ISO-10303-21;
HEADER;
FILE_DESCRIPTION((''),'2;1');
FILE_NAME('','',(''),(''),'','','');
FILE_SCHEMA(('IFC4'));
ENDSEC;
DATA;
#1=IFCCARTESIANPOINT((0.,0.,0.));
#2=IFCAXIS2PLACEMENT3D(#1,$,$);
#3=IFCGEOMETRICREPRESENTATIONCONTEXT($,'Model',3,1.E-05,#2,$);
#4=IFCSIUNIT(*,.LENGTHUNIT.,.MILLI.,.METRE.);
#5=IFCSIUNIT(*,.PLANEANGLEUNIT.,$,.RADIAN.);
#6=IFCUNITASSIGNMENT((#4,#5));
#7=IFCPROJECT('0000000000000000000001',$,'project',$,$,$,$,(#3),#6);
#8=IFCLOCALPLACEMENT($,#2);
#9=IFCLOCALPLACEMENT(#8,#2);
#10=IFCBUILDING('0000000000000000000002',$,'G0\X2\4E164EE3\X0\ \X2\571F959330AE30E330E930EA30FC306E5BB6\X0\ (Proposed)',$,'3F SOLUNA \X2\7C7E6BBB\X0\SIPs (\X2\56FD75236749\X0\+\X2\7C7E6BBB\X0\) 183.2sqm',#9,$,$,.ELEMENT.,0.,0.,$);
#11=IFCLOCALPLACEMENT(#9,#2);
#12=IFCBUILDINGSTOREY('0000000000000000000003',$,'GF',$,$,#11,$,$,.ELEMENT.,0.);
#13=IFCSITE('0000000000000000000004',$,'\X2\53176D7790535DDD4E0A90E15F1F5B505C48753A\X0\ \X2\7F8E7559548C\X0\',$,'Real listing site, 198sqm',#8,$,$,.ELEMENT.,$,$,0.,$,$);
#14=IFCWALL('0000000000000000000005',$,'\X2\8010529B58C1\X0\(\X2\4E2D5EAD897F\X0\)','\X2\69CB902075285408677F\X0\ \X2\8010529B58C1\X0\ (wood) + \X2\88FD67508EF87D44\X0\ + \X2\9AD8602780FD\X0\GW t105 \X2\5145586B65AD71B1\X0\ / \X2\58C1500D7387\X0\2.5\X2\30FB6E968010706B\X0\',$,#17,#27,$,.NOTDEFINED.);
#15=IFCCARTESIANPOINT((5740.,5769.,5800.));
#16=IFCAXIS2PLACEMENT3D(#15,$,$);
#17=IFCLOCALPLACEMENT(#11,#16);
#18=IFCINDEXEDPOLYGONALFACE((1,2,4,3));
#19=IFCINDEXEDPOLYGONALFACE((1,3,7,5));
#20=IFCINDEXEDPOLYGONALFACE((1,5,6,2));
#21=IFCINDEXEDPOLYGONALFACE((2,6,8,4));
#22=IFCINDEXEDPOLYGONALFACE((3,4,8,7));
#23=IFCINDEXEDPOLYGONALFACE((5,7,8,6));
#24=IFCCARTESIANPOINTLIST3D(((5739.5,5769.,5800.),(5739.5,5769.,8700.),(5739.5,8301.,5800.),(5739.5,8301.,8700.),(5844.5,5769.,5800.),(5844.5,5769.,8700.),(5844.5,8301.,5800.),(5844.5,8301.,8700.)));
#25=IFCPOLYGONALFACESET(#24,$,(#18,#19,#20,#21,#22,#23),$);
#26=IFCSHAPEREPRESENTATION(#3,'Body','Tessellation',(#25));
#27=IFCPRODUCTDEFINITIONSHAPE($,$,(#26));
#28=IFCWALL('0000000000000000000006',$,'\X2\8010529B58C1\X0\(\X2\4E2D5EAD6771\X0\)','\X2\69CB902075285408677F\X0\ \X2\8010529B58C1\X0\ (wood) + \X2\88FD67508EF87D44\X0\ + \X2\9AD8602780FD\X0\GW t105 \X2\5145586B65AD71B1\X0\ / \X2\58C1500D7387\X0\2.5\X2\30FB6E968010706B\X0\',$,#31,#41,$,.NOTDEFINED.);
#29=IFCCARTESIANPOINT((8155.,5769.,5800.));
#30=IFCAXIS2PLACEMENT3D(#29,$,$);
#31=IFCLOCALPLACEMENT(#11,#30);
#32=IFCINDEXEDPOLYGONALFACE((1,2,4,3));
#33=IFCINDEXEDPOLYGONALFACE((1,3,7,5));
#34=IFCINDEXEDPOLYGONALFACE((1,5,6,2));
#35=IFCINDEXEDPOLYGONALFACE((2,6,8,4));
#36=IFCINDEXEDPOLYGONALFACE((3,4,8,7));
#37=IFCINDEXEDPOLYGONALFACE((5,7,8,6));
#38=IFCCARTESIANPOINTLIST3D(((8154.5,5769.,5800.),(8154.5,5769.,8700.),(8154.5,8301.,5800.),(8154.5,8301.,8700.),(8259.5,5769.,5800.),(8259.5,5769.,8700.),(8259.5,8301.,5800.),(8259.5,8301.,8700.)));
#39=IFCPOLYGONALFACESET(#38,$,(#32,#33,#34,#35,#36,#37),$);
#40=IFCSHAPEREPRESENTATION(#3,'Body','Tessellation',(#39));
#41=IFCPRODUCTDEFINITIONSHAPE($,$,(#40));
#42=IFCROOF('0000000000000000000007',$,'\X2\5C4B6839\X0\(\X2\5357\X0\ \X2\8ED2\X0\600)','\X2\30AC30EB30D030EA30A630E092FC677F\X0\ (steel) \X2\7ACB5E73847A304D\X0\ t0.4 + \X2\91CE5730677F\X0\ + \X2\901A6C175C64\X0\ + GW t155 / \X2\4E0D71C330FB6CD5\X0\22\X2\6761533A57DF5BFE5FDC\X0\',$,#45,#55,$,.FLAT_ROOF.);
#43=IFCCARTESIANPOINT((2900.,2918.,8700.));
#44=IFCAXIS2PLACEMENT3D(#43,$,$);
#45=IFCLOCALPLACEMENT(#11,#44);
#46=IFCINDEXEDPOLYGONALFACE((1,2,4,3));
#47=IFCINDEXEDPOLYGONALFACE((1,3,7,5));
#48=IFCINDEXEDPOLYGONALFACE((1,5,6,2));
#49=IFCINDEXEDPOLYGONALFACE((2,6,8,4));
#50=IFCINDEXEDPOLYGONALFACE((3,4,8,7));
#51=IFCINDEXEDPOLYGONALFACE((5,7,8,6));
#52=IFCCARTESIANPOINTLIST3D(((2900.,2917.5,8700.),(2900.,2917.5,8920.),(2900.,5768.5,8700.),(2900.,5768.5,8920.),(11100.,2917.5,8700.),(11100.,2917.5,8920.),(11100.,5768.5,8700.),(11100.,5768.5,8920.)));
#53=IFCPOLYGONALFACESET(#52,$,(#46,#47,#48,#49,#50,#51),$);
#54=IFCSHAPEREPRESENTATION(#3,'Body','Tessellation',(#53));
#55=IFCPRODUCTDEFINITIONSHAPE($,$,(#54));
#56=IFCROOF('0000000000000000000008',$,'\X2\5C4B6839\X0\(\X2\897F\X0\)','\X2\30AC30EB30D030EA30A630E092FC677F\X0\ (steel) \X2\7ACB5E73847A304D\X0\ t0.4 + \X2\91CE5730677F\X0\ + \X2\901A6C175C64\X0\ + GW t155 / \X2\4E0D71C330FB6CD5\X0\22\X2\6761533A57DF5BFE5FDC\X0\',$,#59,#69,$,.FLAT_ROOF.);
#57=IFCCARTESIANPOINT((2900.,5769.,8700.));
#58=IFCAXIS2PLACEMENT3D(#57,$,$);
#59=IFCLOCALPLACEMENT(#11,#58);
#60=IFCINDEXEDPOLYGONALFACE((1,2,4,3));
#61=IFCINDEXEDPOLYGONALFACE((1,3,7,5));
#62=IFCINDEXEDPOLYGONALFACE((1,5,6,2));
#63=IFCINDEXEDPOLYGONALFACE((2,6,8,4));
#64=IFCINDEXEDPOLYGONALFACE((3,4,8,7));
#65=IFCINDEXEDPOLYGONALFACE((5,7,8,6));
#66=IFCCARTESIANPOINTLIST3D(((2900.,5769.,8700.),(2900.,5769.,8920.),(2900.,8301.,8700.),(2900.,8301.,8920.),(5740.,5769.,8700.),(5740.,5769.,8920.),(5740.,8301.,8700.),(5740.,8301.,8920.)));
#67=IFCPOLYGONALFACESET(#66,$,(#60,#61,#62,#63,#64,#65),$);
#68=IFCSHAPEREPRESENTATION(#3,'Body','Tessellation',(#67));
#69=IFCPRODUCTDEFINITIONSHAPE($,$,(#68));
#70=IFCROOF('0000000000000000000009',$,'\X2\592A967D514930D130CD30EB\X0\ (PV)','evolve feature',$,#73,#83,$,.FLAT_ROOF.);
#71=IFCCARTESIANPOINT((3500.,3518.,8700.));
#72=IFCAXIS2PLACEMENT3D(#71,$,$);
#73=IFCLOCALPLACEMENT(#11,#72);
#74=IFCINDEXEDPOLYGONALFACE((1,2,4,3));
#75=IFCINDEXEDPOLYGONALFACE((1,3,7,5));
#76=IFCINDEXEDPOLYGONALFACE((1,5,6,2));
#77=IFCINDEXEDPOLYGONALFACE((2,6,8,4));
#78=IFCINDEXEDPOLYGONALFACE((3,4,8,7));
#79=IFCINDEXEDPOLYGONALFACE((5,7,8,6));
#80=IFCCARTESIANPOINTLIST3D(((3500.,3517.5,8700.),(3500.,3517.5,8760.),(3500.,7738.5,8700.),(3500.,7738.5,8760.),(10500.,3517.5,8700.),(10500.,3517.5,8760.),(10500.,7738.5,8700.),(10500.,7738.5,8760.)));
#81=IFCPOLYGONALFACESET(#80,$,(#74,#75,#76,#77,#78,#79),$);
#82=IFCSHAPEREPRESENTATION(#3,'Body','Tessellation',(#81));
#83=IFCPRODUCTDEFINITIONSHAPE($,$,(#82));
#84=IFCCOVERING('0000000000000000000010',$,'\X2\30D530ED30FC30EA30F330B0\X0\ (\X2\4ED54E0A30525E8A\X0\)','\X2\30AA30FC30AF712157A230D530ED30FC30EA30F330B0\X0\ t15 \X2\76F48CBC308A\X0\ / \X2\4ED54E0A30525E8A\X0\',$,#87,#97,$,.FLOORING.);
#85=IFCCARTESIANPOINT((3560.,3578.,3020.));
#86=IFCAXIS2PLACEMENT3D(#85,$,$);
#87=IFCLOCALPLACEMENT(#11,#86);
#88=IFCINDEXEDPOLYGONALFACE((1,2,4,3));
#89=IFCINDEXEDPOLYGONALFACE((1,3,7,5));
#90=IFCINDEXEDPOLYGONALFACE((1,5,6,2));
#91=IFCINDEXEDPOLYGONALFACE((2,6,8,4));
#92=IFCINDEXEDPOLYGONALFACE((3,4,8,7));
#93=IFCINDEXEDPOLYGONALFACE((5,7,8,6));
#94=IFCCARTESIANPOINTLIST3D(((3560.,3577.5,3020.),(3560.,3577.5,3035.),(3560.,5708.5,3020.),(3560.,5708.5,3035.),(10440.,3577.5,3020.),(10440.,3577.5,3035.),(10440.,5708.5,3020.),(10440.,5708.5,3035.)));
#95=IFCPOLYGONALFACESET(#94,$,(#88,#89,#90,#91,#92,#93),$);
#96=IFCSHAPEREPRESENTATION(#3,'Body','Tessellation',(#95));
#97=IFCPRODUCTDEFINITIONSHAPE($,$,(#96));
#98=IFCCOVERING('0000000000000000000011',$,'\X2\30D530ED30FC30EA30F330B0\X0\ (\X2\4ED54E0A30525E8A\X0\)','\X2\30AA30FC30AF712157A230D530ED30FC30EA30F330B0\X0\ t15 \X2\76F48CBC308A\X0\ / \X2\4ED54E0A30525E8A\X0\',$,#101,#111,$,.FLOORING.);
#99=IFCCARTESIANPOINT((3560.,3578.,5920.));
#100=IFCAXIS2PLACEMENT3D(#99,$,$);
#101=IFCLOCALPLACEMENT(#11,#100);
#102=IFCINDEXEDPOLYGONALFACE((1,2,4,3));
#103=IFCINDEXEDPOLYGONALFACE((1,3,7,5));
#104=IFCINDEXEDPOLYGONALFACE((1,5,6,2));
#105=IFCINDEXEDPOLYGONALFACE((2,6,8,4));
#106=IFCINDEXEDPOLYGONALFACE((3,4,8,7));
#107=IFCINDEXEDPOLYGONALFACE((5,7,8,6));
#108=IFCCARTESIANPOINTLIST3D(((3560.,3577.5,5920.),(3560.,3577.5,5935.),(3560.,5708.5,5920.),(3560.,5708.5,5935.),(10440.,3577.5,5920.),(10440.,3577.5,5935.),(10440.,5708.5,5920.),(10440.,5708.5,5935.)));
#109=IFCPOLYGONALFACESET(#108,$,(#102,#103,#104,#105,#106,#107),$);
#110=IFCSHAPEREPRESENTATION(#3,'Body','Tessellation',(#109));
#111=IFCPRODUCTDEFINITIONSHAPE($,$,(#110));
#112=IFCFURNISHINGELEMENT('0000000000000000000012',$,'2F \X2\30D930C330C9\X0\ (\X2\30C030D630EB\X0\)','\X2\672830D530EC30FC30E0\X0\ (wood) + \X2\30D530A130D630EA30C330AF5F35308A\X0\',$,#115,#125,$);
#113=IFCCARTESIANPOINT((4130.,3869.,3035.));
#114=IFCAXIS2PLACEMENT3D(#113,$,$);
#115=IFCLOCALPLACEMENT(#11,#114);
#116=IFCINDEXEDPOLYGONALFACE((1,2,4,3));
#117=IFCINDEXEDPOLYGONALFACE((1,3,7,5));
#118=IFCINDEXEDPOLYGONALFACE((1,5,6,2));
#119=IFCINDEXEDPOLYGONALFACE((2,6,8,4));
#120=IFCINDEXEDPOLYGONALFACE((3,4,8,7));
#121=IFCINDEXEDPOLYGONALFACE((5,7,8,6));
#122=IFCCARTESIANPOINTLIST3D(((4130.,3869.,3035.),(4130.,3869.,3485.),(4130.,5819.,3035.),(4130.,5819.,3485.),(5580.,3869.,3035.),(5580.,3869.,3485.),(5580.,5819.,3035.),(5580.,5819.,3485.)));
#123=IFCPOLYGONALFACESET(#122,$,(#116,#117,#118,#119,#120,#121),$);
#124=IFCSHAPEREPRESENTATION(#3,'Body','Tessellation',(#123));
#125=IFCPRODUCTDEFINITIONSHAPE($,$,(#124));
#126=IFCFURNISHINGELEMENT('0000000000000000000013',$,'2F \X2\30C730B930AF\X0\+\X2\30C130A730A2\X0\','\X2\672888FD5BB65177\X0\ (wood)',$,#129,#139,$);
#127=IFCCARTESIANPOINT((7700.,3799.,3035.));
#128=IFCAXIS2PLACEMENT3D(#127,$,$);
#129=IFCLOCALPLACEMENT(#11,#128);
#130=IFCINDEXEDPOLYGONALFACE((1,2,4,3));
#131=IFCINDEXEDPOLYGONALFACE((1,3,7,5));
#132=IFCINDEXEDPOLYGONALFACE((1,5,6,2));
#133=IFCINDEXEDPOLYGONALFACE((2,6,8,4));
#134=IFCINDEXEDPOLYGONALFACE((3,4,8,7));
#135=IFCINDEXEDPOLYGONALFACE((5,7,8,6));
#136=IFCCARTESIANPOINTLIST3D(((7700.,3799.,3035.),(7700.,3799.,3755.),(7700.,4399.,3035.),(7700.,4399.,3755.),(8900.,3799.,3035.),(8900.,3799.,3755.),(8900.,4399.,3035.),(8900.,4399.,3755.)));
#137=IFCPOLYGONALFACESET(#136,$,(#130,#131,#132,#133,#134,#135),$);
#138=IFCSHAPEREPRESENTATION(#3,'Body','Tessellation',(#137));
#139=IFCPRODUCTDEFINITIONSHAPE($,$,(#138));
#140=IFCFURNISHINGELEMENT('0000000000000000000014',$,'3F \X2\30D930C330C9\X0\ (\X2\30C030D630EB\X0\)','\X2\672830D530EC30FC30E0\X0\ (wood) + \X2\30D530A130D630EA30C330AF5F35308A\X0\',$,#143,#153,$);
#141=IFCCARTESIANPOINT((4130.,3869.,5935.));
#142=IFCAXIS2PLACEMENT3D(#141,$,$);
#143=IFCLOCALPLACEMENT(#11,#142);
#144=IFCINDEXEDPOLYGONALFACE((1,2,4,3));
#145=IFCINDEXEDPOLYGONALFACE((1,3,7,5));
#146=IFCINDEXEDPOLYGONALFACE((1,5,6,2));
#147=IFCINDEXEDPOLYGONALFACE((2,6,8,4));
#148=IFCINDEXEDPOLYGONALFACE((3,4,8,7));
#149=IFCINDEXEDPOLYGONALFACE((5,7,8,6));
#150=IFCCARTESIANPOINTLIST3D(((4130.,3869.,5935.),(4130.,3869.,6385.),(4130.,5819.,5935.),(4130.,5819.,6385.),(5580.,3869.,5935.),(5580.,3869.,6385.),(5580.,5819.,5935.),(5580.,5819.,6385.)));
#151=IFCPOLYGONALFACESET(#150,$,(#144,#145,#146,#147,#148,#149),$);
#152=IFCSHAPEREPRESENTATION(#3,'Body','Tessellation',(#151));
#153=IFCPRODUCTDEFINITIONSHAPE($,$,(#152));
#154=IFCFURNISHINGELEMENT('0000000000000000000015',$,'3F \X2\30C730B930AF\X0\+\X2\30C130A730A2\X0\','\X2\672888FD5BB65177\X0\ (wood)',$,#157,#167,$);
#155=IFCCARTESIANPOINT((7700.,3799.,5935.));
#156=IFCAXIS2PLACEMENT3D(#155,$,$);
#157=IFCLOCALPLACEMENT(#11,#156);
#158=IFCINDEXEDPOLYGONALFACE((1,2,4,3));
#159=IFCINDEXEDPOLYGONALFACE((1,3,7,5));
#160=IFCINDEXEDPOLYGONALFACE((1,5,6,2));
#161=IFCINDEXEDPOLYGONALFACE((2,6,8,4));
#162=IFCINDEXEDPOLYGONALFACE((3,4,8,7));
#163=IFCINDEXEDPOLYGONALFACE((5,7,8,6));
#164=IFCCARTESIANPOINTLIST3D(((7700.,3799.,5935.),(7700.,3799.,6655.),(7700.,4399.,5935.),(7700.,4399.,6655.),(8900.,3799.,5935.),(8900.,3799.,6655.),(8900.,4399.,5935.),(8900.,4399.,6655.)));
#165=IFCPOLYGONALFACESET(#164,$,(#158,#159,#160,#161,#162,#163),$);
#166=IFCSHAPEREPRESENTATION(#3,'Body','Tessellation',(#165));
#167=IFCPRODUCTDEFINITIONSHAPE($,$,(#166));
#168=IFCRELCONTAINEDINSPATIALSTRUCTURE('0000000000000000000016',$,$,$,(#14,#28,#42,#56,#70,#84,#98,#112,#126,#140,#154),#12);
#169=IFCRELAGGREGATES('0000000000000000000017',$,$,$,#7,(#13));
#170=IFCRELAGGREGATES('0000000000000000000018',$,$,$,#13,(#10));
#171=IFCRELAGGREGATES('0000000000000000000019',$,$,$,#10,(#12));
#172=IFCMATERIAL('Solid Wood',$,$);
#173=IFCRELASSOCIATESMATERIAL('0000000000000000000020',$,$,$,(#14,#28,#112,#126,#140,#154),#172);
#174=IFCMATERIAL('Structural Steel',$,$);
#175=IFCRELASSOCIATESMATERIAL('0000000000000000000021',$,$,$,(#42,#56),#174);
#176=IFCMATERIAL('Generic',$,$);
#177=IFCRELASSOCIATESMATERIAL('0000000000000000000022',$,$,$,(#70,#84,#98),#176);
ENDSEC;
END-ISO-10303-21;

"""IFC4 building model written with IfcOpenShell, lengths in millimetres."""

from ifc_helpers import new_model, si_unit, frame, frame_2d, origin, place, context, project, spatial, rectangle, extrude, material, element, save


model = new_model("IFC4")

# Units and contexts
model_context = context("Model", 3, precision=1e-05, world=origin())
ifc_project = project(units=[si_unit("LENGTHUNIT", "METRE", prefix="MILLI"), si_unit("PLANEANGLEUNIT", "RADIAN")], contexts=[model_context])

# Site, building, storey
site_placement = place(None, origin())
site = spatial("IfcSite", under=ifc_project, at=site_placement, Name="北海道川上郡弟子屈町 美留和", ObjectType="Real listing site, 198sqm", CompositionType="ELEMENT", RefElevation=0.0)
building_placement = place(site_placement, origin())
building = spatial("IfcBuilding", under=site, at=building_placement, Name="G0世代 土間ギャラリーの家 (Proposed)", ObjectType="3F SOLUNA 籾殻SIPs (国産杉+籾殻) 183.2sqm", CompositionType="ELEMENT", ElevationOfRefHeight=0.0, ElevationOfTerrain=0.0)
storey_placement = place(building_placement, origin())
storey = spatial("IfcBuildingStorey", under=building, at=storey_placement, Name="GF", CompositionType="ELEMENT", Elevation=0.0)

# Shared definitions
ifc_material_1 = material(Name="Solid Wood")

# Walls
wall_1_placement = place(storey_placement, frame((5740.0, 5769.0, 5800.0)))
element("IfcWall", 1, at=wall_1_placement, inside=storey, material=ifc_material_1, Name="耐力壁(中庭西)", Description="構造用合板 耐力壁 (wood) + 製材軸組 + 高性能GW t105 充填断熱 / 壁倍率2.5・準耐火", PredefinedType="NOTDEFINED", context=model_context, shape_type="SweptSolid", body=[
    extrude(rectangle(XDim=105.0, YDim=2532.0, at=frame_2d((52.0, 1266.0))), frame((5740.0, 5769.0, 5800.0)), (0.0, 0.0, 1.0), 2900.0),
])
wall_2_placement = place(storey_placement, frame((8155.0, 5769.0, 5800.0)))
element("IfcWall", 2, at=wall_2_placement, inside=storey, material=ifc_material_1, Name="耐力壁(中庭東)", Description="構造用合板 耐力壁 (wood) + 製材軸組 + 高性能GW t105 充填断熱 / 壁倍率2.5・準耐火", PredefinedType="NOTDEFINED", context=model_context, shape_type="SweptSolid", body=[
    extrude(rectangle(XDim=105.0, YDim=2532.0, at=frame_2d((52.0, 1266.0))), frame((8155.0, 5769.0, 5800.0)), (0.0, 0.0, 1.0), 2900.0),
])

# Roofs
ifc_material_2 = material(Name="Structural Steel")
roof_1_placement = place(storey_placement, frame((2900.0, 2918.0, 8700.0)))
element("IfcRoof", 3, at=roof_1_placement, inside=storey, material=ifc_material_2, Name="屋根(南 軒600)", Description="ガルバリウム鋼板 (steel) 立平葺き t0.4 + 野地板 + 通気層 + GW t155 / 不燃・法22条区域対応", PredefinedType="FLAT_ROOF", context=model_context, shape_type="SweptSolid", body=[
    extrude(rectangle(XDim=8200.0, YDim=2851.0, at=frame_2d((4100.0, 1425.0))), frame((2900.0, 2918.0, 8700.0)), (0.0, 0.0, 1.0), 220.0),
])
roof_2_placement = place(storey_placement, frame((2900.0, 5769.0, 8700.0)))
element("IfcRoof", 4, at=roof_2_placement, inside=storey, material=ifc_material_2, Name="屋根(西)", Description="ガルバリウム鋼板 (steel) 立平葺き t0.4 + 野地板 + 通気層 + GW t155 / 不燃・法22条区域対応", PredefinedType="FLAT_ROOF", context=model_context, shape_type="SweptSolid", body=[
    extrude(rectangle(XDim=2840.0, YDim=2532.0, at=frame_2d((1420.0, 1266.0))), frame((2900.0, 5769.0, 8700.0)), (0.0, 0.0, 1.0), 220.0),
])
ifc_material_3 = material(Name="Generic")
roof_3_placement = place(storey_placement, frame((3500.0, 3518.0, 8700.0)))
element("IfcRoof", 5, at=roof_3_placement, inside=storey, material=ifc_material_3, Name="太陽光パネル (PV)", Description="evolve feature", PredefinedType="FLAT_ROOF", context=model_context, shape_type="SweptSolid", body=[
    extrude(rectangle(XDim=7000.0, YDim=4221.0, at=frame_2d((3500.0, 2110.0))), frame((3500.0, 3518.0, 8700.0)), (0.0, 0.0, 1.0), 60.0),
])

# Coverings
covering_1_placement = place(storey_placement, frame((3560.0, 3578.0, 3020.0)))
element("IfcCovering", 6, at=covering_1_placement, inside=storey, material=ifc_material_3, Name="フローリング (仕上げ床)", Description="オーク無垢フローリング t15 直貼り / 仕上げ床", PredefinedType="FLOORING", context=model_context, shape_type="SweptSolid", body=[
    extrude(rectangle(XDim=6880.0, YDim=2131.0, at=frame_2d((3440.0, 1065.0))), frame((3560.0, 3578.0, 3020.0)), (0.0, 0.0, 1.0), 15.0),
])
covering_2_placement = place(storey_placement, frame((3560.0, 3578.0, 5920.0)))
element("IfcCovering", 7, at=covering_2_placement, inside=storey, material=ifc_material_3, Name="フローリング (仕上げ床)", Description="オーク無垢フローリング t15 直貼り / 仕上げ床", PredefinedType="FLOORING", context=model_context, shape_type="SweptSolid", body=[
    extrude(rectangle(XDim=6880.0, YDim=2131.0, at=frame_2d((3440.0, 1065.0))), frame((3560.0, 3578.0, 5920.0)), (0.0, 0.0, 1.0), 15.0),
])

# Furnishing elements
furnishing_1_placement = place(storey_placement, frame((4130.0, 3869.0, 3035.0)))
element("IfcFurnishingElement", 8, at=furnishing_1_placement, inside=storey, material=ifc_material_1, Name="2F ベッド (ダブル)", Description="木フレーム (wood) + ファブリック張り", context=model_context, shape_type="SweptSolid", body=[
    extrude(rectangle(XDim=1450.0, YDim=1950.0, at=frame_2d((725.0, 975.0))), frame((4130.0, 3869.0, 3035.0)), (0.0, 0.0, 1.0), 450.0),
])
furnishing_2_placement = place(storey_placement, frame((7700.0, 3799.0, 3035.0)))
element("IfcFurnishingElement", 9, at=furnishing_2_placement, inside=storey, material=ifc_material_1, Name="2F デスク+チェア", Description="木製家具 (wood)", context=model_context, shape_type="SweptSolid", body=[
    extrude(rectangle(XDim=1200.0, YDim=600.0, at=frame_2d((600.0, 300.0))), frame((7700.0, 3799.0, 3035.0)), (0.0, 0.0, 1.0), 720.0),
])
furnishing_3_placement = place(storey_placement, frame((4130.0, 3869.0, 5935.0)))
element("IfcFurnishingElement", 10, at=furnishing_3_placement, inside=storey, material=ifc_material_1, Name="3F ベッド (ダブル)", Description="木フレーム (wood) + ファブリック張り", context=model_context, shape_type="SweptSolid", body=[
    extrude(rectangle(XDim=1450.0, YDim=1950.0, at=frame_2d((725.0, 975.0))), frame((4130.0, 3869.0, 5935.0)), (0.0, 0.0, 1.0), 450.0),
])
furnishing_4_placement = place(storey_placement, frame((7700.0, 3799.0, 5935.0)))
element("IfcFurnishingElement", 11, at=furnishing_4_placement, inside=storey, material=ifc_material_1, Name="3F デスク+チェア", Description="木製家具 (wood)", context=model_context, shape_type="SweptSolid", body=[
    extrude(rectangle(XDim=1200.0, YDim=600.0, at=frame_2d((600.0, 300.0))), frame((7700.0, 3799.0, 5935.0)), (0.0, 0.0, 1.0), 720.0),
])

save(model, "model.ifc")
